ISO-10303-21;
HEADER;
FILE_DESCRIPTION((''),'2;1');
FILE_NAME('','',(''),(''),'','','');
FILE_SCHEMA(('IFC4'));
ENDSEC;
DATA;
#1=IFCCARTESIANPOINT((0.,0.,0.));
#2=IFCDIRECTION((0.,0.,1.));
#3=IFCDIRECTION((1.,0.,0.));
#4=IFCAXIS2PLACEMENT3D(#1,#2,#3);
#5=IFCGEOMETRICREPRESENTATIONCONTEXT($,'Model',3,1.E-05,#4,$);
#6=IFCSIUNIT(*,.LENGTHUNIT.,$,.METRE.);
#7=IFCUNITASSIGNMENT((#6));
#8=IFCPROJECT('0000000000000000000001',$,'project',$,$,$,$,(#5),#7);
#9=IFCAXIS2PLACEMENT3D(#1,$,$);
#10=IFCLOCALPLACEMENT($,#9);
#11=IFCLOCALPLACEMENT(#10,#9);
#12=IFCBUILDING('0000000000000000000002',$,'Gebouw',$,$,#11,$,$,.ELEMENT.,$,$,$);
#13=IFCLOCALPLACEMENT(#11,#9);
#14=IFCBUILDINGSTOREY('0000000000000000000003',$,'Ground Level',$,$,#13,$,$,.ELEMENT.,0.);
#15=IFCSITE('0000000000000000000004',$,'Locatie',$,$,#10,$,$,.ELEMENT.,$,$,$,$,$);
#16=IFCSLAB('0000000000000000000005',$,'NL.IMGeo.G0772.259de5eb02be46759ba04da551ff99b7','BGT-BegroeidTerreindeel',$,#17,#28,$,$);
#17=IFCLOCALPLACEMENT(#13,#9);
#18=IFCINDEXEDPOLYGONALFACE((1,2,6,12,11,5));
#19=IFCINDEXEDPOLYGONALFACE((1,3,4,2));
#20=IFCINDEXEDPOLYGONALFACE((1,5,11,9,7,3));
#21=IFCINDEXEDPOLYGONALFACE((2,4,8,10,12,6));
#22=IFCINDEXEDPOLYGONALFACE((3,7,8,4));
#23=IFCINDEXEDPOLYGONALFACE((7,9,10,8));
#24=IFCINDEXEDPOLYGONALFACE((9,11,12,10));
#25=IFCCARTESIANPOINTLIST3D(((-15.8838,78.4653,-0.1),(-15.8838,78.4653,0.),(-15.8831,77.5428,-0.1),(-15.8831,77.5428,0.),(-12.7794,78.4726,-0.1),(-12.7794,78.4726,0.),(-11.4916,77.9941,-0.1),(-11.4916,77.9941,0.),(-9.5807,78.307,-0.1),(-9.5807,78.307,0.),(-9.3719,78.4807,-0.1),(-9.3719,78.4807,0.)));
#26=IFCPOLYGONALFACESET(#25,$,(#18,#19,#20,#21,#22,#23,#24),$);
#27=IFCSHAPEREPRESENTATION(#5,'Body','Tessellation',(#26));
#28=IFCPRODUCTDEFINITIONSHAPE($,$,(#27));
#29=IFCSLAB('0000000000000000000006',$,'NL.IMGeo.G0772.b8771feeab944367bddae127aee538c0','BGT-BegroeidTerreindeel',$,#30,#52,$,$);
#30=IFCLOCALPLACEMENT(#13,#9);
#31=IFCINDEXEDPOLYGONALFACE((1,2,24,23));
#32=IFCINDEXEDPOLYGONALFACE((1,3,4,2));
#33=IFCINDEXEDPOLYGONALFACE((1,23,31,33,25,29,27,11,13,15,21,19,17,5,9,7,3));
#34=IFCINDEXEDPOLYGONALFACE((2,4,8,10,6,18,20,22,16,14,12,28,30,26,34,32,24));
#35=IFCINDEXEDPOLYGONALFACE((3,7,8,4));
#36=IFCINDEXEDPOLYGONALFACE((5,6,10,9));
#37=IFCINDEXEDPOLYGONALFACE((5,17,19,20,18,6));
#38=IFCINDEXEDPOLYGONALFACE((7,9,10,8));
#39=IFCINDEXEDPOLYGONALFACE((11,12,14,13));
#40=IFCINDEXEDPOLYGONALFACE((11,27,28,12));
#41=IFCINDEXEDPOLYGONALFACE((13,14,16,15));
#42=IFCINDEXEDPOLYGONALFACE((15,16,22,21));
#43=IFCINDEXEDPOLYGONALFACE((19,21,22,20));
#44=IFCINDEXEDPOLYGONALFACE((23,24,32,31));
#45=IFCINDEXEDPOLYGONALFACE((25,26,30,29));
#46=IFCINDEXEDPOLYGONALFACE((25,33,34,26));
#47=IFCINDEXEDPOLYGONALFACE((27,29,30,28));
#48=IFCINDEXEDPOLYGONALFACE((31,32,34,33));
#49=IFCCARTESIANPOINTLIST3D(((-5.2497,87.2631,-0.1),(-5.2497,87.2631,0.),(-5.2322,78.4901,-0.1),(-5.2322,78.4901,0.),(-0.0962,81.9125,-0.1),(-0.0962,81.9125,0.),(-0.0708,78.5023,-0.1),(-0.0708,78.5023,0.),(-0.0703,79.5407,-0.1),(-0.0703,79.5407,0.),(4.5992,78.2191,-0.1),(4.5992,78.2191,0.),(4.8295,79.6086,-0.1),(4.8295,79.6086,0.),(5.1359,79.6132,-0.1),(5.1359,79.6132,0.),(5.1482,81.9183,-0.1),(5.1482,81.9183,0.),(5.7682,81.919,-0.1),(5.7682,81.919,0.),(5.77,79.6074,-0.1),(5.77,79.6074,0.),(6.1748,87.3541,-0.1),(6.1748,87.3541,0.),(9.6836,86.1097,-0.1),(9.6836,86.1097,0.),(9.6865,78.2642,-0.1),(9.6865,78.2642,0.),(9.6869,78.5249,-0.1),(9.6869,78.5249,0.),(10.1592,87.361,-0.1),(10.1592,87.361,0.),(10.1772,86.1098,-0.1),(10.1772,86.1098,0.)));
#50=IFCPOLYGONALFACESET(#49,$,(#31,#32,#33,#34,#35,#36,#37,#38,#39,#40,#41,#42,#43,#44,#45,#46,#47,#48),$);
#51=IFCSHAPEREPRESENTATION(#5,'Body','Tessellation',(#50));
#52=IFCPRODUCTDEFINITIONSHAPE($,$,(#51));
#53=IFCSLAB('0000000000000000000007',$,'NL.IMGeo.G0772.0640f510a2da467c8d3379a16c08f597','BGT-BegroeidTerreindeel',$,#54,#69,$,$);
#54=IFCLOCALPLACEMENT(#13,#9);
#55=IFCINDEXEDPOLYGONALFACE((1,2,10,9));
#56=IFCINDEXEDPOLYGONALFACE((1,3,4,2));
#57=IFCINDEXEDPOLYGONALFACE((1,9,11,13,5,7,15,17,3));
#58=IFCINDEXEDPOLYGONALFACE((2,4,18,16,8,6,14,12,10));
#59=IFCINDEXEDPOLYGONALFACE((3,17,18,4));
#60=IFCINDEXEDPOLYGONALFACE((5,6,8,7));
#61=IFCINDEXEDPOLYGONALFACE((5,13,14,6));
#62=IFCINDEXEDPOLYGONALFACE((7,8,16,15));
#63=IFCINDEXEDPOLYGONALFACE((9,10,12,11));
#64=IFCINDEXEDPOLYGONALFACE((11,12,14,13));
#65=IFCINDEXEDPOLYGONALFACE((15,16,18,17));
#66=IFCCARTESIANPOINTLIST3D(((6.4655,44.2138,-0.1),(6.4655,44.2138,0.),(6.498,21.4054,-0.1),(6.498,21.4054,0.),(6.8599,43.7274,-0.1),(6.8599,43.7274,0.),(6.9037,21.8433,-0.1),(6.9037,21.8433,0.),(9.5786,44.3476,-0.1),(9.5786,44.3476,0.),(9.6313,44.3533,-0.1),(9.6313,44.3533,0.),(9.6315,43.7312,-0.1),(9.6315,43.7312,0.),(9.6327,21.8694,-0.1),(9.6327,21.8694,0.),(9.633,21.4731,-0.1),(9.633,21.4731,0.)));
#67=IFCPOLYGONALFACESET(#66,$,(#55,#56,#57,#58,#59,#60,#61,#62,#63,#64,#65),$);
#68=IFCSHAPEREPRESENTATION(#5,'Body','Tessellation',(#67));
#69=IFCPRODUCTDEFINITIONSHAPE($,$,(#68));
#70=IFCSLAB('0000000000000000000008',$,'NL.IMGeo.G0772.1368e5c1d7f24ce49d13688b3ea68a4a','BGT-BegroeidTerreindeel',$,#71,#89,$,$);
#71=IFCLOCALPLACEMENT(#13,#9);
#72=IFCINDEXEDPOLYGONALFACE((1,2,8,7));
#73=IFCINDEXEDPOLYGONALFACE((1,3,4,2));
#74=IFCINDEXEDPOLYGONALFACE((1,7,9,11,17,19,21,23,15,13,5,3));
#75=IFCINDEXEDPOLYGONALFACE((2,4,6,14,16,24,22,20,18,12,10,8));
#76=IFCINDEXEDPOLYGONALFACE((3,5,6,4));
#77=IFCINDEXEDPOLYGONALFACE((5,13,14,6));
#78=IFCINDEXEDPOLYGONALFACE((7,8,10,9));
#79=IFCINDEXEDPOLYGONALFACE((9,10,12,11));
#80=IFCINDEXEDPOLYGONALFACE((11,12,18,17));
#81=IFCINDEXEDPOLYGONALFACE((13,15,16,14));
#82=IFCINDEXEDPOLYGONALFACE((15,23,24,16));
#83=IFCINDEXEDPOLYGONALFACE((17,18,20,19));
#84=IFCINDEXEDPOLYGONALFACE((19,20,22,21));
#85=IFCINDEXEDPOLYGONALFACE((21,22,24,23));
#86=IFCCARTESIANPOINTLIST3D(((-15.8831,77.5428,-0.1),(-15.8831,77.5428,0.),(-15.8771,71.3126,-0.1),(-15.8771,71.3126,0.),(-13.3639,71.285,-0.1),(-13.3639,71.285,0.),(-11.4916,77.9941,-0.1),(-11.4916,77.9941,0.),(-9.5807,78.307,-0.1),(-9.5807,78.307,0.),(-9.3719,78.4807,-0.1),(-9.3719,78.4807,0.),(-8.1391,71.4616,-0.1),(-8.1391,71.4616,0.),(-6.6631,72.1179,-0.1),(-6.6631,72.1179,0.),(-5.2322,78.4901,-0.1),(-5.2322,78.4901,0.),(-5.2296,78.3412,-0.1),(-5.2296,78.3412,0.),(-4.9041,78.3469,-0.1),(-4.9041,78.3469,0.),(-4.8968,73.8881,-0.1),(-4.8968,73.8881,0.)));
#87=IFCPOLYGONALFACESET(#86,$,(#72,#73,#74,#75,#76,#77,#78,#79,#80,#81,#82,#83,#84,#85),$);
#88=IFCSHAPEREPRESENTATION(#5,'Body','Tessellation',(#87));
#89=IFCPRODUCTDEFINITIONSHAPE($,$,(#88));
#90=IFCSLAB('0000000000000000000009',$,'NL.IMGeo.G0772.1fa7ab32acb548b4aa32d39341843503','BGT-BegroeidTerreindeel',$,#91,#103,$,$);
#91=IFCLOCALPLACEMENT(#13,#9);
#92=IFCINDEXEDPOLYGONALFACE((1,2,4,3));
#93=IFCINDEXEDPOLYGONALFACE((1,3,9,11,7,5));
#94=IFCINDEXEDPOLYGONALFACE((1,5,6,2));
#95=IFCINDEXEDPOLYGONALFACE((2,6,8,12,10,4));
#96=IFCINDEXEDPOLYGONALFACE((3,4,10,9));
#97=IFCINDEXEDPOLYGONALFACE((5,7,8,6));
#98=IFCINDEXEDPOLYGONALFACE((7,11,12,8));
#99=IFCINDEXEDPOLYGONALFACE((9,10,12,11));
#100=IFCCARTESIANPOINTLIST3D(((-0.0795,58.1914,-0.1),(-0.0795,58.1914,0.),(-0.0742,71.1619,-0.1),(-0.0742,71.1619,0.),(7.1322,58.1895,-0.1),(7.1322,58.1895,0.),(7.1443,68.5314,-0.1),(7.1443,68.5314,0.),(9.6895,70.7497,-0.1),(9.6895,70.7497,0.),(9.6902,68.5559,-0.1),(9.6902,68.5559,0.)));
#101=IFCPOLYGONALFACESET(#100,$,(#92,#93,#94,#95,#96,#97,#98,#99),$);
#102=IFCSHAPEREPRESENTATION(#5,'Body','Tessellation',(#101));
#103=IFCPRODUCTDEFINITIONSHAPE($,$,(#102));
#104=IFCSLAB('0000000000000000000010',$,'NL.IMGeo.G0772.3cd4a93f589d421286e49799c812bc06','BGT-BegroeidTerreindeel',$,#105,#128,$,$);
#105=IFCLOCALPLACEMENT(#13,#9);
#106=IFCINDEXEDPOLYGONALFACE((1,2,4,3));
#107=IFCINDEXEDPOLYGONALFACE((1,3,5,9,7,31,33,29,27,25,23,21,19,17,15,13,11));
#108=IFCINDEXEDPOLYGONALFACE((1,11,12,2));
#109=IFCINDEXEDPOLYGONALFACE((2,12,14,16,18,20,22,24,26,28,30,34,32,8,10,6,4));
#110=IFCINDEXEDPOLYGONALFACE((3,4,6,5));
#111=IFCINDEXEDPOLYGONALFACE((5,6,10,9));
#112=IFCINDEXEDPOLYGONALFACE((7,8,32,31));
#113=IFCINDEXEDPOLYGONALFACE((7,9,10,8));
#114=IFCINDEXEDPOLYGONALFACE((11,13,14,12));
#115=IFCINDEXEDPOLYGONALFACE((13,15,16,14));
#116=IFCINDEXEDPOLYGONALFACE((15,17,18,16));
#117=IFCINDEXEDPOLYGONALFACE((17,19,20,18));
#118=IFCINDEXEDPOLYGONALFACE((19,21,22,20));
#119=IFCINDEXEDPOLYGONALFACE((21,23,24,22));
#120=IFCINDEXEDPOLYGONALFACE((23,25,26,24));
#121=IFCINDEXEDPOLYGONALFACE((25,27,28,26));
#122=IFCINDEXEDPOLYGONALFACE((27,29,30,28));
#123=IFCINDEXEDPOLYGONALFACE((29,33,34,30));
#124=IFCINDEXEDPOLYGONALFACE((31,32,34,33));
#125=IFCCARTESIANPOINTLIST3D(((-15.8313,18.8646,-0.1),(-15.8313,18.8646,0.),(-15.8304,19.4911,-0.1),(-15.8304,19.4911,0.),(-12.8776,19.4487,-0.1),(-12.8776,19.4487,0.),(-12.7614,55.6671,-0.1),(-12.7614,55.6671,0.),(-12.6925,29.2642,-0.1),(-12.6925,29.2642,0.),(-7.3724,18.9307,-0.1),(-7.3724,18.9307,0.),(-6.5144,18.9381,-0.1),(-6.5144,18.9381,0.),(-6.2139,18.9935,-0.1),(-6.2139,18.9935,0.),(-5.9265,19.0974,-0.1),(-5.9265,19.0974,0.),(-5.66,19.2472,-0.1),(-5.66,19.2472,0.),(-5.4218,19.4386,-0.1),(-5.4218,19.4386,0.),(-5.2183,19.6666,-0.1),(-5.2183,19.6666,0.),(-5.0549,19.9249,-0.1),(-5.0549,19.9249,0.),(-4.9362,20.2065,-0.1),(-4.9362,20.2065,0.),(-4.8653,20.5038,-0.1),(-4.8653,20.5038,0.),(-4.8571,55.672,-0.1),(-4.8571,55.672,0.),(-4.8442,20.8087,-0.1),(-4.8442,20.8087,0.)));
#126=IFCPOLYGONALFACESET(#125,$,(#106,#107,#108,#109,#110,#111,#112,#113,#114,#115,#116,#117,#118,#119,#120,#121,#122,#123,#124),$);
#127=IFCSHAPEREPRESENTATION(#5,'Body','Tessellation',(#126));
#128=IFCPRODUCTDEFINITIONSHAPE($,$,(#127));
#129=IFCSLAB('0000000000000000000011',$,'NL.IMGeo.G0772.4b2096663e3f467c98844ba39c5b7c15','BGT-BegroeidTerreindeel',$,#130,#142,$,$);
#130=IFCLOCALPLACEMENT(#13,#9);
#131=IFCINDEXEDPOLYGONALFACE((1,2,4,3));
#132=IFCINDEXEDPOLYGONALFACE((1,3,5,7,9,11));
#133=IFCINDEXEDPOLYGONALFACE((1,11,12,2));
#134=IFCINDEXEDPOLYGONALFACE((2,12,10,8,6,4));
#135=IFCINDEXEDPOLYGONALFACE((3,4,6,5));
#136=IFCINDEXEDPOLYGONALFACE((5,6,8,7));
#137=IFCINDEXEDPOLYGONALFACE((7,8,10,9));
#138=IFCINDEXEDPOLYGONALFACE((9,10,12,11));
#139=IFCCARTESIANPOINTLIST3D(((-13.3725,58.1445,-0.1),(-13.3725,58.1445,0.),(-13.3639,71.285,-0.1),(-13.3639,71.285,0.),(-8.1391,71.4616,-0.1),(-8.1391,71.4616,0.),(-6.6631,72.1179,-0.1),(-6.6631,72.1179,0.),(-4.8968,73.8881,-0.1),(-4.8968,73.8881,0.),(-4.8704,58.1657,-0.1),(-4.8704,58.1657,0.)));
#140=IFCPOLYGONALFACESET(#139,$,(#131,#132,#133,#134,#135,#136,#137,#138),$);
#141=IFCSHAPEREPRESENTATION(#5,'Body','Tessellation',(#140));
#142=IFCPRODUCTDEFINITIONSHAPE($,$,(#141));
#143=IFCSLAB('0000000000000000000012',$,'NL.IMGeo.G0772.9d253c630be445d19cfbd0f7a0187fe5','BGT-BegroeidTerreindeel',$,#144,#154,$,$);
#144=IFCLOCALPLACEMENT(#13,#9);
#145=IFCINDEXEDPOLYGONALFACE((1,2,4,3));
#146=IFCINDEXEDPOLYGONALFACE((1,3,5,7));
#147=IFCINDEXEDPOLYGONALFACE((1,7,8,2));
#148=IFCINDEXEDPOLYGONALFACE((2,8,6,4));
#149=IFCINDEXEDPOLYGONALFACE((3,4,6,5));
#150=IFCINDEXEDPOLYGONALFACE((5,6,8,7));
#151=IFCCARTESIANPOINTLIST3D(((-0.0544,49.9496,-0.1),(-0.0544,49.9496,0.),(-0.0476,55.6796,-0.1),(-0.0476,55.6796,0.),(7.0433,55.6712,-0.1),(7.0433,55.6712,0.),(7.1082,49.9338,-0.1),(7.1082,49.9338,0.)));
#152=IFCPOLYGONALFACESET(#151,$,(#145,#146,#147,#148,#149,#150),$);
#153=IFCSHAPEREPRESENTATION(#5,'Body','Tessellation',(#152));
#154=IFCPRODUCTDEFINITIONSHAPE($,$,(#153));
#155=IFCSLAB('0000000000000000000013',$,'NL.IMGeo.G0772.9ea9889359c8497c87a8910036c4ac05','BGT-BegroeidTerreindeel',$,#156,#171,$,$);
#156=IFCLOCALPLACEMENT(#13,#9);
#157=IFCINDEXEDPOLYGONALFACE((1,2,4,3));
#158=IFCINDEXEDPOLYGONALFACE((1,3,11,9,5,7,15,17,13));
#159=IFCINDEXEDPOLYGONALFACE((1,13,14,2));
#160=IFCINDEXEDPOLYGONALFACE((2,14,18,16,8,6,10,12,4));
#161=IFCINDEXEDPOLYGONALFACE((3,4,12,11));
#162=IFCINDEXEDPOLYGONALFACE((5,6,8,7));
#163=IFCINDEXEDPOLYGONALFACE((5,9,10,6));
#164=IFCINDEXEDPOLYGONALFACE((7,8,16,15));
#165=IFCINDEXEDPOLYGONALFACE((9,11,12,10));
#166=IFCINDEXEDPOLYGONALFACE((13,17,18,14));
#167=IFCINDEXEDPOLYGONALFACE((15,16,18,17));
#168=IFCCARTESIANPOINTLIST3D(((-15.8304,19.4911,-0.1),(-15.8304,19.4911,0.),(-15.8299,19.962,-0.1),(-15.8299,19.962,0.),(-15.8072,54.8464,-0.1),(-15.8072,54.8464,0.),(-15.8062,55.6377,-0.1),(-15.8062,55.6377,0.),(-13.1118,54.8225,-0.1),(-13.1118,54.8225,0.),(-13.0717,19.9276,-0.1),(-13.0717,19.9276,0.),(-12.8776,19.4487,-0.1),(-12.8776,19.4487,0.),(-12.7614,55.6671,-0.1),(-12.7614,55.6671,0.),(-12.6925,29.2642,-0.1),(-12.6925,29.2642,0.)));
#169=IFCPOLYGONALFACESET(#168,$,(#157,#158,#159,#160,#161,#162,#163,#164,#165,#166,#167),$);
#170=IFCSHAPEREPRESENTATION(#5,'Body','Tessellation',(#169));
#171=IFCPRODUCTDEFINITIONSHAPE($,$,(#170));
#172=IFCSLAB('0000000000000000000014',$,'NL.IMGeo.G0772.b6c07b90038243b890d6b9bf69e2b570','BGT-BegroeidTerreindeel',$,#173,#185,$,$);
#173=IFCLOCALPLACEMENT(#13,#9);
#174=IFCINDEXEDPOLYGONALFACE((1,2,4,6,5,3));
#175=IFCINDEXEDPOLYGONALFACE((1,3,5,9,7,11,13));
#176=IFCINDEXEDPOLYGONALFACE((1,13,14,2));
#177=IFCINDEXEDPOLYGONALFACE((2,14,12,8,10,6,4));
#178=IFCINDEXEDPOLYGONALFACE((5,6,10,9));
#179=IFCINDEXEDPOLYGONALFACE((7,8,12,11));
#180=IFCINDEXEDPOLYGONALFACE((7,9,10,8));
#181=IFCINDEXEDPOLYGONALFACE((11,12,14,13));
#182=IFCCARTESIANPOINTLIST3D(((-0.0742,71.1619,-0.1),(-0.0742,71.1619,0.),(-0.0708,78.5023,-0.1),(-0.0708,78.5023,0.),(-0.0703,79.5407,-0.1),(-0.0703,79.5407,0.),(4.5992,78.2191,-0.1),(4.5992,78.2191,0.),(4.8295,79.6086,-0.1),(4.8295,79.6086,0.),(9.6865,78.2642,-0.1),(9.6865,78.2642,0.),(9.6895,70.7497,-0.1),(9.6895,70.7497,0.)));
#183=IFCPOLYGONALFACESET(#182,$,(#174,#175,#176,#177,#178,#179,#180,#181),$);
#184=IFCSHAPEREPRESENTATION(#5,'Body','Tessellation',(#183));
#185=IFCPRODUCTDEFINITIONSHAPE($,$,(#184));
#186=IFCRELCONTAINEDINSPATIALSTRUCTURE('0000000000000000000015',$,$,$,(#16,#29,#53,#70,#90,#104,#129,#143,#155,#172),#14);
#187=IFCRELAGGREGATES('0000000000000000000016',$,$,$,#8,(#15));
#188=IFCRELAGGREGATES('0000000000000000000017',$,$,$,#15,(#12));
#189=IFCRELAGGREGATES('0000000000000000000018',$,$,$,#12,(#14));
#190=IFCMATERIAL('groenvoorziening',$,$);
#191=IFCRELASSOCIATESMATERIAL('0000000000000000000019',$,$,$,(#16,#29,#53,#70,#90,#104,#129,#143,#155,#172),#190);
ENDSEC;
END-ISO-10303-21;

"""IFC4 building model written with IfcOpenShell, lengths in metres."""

from ifc_helpers import new_model, si_unit, frame, origin, origin_with_axes, place, context, project, spatial, polyline, outline, extrude, material, element, save


model = new_model("IFC4")

# Units and contexts
model_context = context("Model", 3, precision=1e-05, world=origin_with_axes())
ifc_project = project(units=[si_unit("LENGTHUNIT", "METRE")], contexts=[model_context])

# Site, building, storey
site_placement = place(None, origin())
site = spatial("IfcSite", under=ifc_project, at=site_placement, Name="Locatie", CompositionType="ELEMENT")
building_placement = place(site_placement, origin())
building = spatial("IfcBuilding", under=site, at=building_placement, Name="Gebouw", CompositionType="ELEMENT")
storey_placement = place(building_placement, origin())
storey = spatial("IfcBuildingStorey", under=building, at=storey_placement, Name="Ground Level", CompositionType="ELEMENT", Elevation=0.0)

# Slabs
ifc_material = material(Name="groenvoorziening")
slab_1_placement = place(storey_placement, origin())
element("IfcSlab", 1, at=slab_1_placement, inside=storey, material=ifc_material, Name="NL.IMGeo.G0772.259de5eb02be46759ba04da551ff99b7", Description="BGT-BegroeidTerreindeel", context=model_context, shape_type="SweptSolid", body=[
    extrude(outline(polyline([(-12.7794, 78.4726), (-9.3719, 78.4807), (-9.5807, 78.307), (-11.4916, 77.9941), (-15.8831, 77.5428), (-15.8838, 78.4653), (-12.7794, 78.4726)])), frame((0.0, 0.0, -0.1), z_axis=(0.0, 0.0, 1.0), x_axis=(1.0, 0.0, 0.0)), (0.0, 0.0, 1.0), 0.1),
])
slab_2_placement = place(storey_placement, origin())
element("IfcSlab", 2, at=slab_2_placement, inside=storey, material=ifc_material, Name="NL.IMGeo.G0772.b8771feeab944367bddae127aee538c0", Description="BGT-BegroeidTerreindeel", context=model_context, shape_type="SweptSolid", body=[
    extrude(outline(polyline([(6.1748, 87.3541), (10.1592, 87.361), (10.1772, 86.1098), (9.6836, 86.1097), (9.6869, 78.5249), (9.6865, 78.2642), (4.5992, 78.2191), (4.8295, 79.6086), (5.1359, 79.6132), (5.77, 79.6074), (5.7682, 81.919), (5.1482, 81.9183), (-0.0962, 81.9125), (-0.0703, 79.5407), (-0.0708, 78.5023), (-5.2322, 78.4901), (-5.2497, 87.2631), (6.1748, 87.3541)])), frame((0.0, 0.0, -0.1), z_axis=(0.0, 0.0, 1.0), x_axis=(1.0, 0.0, 0.0)), (0.0, 0.0, 1.0), 0.1),
])
slab_3_placement = place(storey_placement, origin())
element("IfcSlab", 3, at=slab_3_placement, inside=storey, material=ifc_material, Name="NL.IMGeo.G0772.0640f510a2da467c8d3379a16c08f597", Description="BGT-BegroeidTerreindeel", context=model_context, shape_type="SweptSolid", body=[
    extrude(outline(polyline([(6.8599, 43.7274), (6.9037, 21.8433), (9.6327, 21.8694), (9.633, 21.4731), (6.498, 21.4054), (6.4655, 44.2138), (9.5786, 44.3476), (9.6313, 44.3533), (9.6315, 43.7312), (6.8599, 43.7274)])), frame((0.0, 0.0, -0.1), z_axis=(0.0, 0.0, 1.0), x_axis=(1.0, 0.0, 0.0)), (0.0, 0.0, 1.0), 0.1),
])
slab_4_placement = place(storey_placement, origin())
element("IfcSlab", 4, at=slab_4_placement, inside=storey, material=ifc_material, Name="NL.IMGeo.G0772.1368e5c1d7f24ce49d13688b3ea68a4a", Description="BGT-BegroeidTerreindeel", context=model_context, shape_type="SweptSolid", body=[
    extrude(outline(polyline([(-4.8968, 73.8881), (-6.6631, 72.1179), (-8.1391, 71.4616), (-13.3639, 71.285), (-15.8771, 71.3126), (-15.8831, 77.5428), (-11.4916, 77.9941), (-9.5807, 78.307), (-9.3719, 78.4807), (-5.2322, 78.4901), (-5.2296, 78.3412), (-4.9041, 78.3469), (-4.8968, 73.8881)])), frame((0.0, 0.0, -0.1), z_axis=(0.0, 0.0, 1.0), x_axis=(1.0, 0.0, 0.0)), (0.0, 0.0, 1.0), 0.1),
])
slab_5_placement = place(storey_placement, origin())
element("IfcSlab", 5, at=slab_5_placement, inside=storey, material=ifc_material, Name="NL.IMGeo.G0772.1fa7ab32acb548b4aa32d39341843503", Description="BGT-BegroeidTerreindeel", context=model_context, shape_type="SweptSolid", body=[
    extrude(outline(polyline([(7.1443, 68.5314), (7.1322, 58.1895), (-0.0795, 58.1914), (-0.0742, 71.1619), (9.6895, 70.7497), (9.6902, 68.5559), (7.1443, 68.5314)])), frame((0.0, 0.0, -0.1), z_axis=(0.0, 0.0, 1.0), x_axis=(1.0, 0.0, 0.0)), (0.0, 0.0, 1.0), 0.1),
])
slab_6_placement = place(storey_placement, origin())
element("IfcSlab", 6, at=slab_6_placement, inside=storey, material=ifc_material, Name="NL.IMGeo.G0772.3cd4a93f589d421286e49799c812bc06", Description="BGT-BegroeidTerreindeel", context=model_context, shape_type="SweptSolid", body=[
    extrude(outline(polyline([(-4.8571, 55.672), (-4.8442, 20.8087), (-4.8653, 20.5038), (-4.9362, 20.2065), (-5.0549, 19.9249), (-5.2183, 19.6666), (-5.4218, 19.4386), (-5.66, 19.2472), (-5.9265, 19.0974), (-6.2139, 18.9935), (-6.5144, 18.9381), (-7.3724, 18.9307), (-15.8313, 18.8646), (-15.8304, 19.4911), (-12.8776, 19.4487), (-12.6925, 29.2642), (-12.7614, 55.6671), (-4.8571, 55.672)])), frame((0.0, 0.0, -0.1), z_axis=(0.0, 0.0, 1.0), x_axis=(1.0, 0.0, 0.0)), (0.0, 0.0, 1.0), 0.1),
])
slab_7_placement = place(storey_placement, origin())
element("IfcSlab", 7, at=slab_7_placement, inside=storey, material=ifc_material, Name="NL.IMGeo.G0772.4b2096663e3f467c98844ba39c5b7c15", Description="BGT-BegroeidTerreindeel", context=model_context, shape_type="SweptSolid", body=[
    extrude(outline(polyline([(-4.8704, 58.1657), (-13.3725, 58.1445), (-13.3639, 71.285), (-8.1391, 71.4616), (-6.6631, 72.1179), (-4.8968, 73.8881), (-4.8704, 58.1657)])), frame((0.0, 0.0, -0.1), z_axis=(0.0, 0.0, 1.0), x_axis=(1.0, 0.0, 0.0)), (0.0, 0.0, 1.0), 0.1),
])
slab_8_placement = place(storey_placement, origin())
element("IfcSlab", 8, at=slab_8_placement, inside=storey, material=ifc_material, Name="NL.IMGeo.G0772.9d253c630be445d19cfbd0f7a0187fe5", Description="BGT-BegroeidTerreindeel", context=model_context, shape_type="SweptSolid", body=[
    extrude(outline(polyline([(7.0433, 55.6712), (7.1082, 49.9338), (-0.0544, 49.9496), (-0.0476, 55.6796), (7.0433, 55.6712)])), frame((0.0, 0.0, -0.1), z_axis=(0.0, 0.0, 1.0), x_axis=(1.0, 0.0, 0.0)), (0.0, 0.0, 1.0), 0.1),
])
slab_9_placement = place(storey_placement, origin())
element("IfcSlab", 9, at=slab_9_placement, inside=storey, material=ifc_material, Name="NL.IMGeo.G0772.9ea9889359c8497c87a8910036c4ac05", Description="BGT-BegroeidTerreindeel", context=model_context, shape_type="SweptSolid", body=[
    extrude(outline(polyline([(-13.0717, 19.9276), (-13.1118, 54.8225), (-15.8072, 54.8464), (-15.8062, 55.6377), (-12.7614, 55.6671), (-12.6925, 29.2642), (-12.8776, 19.4487), (-15.8304, 19.4911), (-15.8299, 19.962), (-13.0717, 19.9276)])), frame((0.0, 0.0, -0.1), z_axis=(0.0, 0.0, 1.0), x_axis=(1.0, 0.0, 0.0)), (0.0, 0.0, 1.0), 0.1),
])
slab_10_placement = place(storey_placement, origin())
element("IfcSlab", 10, at=slab_10_placement, inside=storey, material=ifc_material, Name="NL.IMGeo.G0772.b6c07b90038243b890d6b9bf69e2b570", Description="BGT-BegroeidTerreindeel", context=model_context, shape_type="SweptSolid", body=[
    extrude(outline(polyline([(4.5992, 78.2191), (9.6865, 78.2642), (9.6895, 70.7497), (-0.0742, 71.1619), (-0.0708, 78.5023), (-0.0703, 79.5407), (4.8295, 79.6086), (4.5992, 78.2191)])), frame((0.0, 0.0, -0.1), z_axis=(0.0, 0.0, 1.0), x_axis=(1.0, 0.0, 0.0)), (0.0, 0.0, 1.0), 0.1),
])

save(model, "model.ifc")
